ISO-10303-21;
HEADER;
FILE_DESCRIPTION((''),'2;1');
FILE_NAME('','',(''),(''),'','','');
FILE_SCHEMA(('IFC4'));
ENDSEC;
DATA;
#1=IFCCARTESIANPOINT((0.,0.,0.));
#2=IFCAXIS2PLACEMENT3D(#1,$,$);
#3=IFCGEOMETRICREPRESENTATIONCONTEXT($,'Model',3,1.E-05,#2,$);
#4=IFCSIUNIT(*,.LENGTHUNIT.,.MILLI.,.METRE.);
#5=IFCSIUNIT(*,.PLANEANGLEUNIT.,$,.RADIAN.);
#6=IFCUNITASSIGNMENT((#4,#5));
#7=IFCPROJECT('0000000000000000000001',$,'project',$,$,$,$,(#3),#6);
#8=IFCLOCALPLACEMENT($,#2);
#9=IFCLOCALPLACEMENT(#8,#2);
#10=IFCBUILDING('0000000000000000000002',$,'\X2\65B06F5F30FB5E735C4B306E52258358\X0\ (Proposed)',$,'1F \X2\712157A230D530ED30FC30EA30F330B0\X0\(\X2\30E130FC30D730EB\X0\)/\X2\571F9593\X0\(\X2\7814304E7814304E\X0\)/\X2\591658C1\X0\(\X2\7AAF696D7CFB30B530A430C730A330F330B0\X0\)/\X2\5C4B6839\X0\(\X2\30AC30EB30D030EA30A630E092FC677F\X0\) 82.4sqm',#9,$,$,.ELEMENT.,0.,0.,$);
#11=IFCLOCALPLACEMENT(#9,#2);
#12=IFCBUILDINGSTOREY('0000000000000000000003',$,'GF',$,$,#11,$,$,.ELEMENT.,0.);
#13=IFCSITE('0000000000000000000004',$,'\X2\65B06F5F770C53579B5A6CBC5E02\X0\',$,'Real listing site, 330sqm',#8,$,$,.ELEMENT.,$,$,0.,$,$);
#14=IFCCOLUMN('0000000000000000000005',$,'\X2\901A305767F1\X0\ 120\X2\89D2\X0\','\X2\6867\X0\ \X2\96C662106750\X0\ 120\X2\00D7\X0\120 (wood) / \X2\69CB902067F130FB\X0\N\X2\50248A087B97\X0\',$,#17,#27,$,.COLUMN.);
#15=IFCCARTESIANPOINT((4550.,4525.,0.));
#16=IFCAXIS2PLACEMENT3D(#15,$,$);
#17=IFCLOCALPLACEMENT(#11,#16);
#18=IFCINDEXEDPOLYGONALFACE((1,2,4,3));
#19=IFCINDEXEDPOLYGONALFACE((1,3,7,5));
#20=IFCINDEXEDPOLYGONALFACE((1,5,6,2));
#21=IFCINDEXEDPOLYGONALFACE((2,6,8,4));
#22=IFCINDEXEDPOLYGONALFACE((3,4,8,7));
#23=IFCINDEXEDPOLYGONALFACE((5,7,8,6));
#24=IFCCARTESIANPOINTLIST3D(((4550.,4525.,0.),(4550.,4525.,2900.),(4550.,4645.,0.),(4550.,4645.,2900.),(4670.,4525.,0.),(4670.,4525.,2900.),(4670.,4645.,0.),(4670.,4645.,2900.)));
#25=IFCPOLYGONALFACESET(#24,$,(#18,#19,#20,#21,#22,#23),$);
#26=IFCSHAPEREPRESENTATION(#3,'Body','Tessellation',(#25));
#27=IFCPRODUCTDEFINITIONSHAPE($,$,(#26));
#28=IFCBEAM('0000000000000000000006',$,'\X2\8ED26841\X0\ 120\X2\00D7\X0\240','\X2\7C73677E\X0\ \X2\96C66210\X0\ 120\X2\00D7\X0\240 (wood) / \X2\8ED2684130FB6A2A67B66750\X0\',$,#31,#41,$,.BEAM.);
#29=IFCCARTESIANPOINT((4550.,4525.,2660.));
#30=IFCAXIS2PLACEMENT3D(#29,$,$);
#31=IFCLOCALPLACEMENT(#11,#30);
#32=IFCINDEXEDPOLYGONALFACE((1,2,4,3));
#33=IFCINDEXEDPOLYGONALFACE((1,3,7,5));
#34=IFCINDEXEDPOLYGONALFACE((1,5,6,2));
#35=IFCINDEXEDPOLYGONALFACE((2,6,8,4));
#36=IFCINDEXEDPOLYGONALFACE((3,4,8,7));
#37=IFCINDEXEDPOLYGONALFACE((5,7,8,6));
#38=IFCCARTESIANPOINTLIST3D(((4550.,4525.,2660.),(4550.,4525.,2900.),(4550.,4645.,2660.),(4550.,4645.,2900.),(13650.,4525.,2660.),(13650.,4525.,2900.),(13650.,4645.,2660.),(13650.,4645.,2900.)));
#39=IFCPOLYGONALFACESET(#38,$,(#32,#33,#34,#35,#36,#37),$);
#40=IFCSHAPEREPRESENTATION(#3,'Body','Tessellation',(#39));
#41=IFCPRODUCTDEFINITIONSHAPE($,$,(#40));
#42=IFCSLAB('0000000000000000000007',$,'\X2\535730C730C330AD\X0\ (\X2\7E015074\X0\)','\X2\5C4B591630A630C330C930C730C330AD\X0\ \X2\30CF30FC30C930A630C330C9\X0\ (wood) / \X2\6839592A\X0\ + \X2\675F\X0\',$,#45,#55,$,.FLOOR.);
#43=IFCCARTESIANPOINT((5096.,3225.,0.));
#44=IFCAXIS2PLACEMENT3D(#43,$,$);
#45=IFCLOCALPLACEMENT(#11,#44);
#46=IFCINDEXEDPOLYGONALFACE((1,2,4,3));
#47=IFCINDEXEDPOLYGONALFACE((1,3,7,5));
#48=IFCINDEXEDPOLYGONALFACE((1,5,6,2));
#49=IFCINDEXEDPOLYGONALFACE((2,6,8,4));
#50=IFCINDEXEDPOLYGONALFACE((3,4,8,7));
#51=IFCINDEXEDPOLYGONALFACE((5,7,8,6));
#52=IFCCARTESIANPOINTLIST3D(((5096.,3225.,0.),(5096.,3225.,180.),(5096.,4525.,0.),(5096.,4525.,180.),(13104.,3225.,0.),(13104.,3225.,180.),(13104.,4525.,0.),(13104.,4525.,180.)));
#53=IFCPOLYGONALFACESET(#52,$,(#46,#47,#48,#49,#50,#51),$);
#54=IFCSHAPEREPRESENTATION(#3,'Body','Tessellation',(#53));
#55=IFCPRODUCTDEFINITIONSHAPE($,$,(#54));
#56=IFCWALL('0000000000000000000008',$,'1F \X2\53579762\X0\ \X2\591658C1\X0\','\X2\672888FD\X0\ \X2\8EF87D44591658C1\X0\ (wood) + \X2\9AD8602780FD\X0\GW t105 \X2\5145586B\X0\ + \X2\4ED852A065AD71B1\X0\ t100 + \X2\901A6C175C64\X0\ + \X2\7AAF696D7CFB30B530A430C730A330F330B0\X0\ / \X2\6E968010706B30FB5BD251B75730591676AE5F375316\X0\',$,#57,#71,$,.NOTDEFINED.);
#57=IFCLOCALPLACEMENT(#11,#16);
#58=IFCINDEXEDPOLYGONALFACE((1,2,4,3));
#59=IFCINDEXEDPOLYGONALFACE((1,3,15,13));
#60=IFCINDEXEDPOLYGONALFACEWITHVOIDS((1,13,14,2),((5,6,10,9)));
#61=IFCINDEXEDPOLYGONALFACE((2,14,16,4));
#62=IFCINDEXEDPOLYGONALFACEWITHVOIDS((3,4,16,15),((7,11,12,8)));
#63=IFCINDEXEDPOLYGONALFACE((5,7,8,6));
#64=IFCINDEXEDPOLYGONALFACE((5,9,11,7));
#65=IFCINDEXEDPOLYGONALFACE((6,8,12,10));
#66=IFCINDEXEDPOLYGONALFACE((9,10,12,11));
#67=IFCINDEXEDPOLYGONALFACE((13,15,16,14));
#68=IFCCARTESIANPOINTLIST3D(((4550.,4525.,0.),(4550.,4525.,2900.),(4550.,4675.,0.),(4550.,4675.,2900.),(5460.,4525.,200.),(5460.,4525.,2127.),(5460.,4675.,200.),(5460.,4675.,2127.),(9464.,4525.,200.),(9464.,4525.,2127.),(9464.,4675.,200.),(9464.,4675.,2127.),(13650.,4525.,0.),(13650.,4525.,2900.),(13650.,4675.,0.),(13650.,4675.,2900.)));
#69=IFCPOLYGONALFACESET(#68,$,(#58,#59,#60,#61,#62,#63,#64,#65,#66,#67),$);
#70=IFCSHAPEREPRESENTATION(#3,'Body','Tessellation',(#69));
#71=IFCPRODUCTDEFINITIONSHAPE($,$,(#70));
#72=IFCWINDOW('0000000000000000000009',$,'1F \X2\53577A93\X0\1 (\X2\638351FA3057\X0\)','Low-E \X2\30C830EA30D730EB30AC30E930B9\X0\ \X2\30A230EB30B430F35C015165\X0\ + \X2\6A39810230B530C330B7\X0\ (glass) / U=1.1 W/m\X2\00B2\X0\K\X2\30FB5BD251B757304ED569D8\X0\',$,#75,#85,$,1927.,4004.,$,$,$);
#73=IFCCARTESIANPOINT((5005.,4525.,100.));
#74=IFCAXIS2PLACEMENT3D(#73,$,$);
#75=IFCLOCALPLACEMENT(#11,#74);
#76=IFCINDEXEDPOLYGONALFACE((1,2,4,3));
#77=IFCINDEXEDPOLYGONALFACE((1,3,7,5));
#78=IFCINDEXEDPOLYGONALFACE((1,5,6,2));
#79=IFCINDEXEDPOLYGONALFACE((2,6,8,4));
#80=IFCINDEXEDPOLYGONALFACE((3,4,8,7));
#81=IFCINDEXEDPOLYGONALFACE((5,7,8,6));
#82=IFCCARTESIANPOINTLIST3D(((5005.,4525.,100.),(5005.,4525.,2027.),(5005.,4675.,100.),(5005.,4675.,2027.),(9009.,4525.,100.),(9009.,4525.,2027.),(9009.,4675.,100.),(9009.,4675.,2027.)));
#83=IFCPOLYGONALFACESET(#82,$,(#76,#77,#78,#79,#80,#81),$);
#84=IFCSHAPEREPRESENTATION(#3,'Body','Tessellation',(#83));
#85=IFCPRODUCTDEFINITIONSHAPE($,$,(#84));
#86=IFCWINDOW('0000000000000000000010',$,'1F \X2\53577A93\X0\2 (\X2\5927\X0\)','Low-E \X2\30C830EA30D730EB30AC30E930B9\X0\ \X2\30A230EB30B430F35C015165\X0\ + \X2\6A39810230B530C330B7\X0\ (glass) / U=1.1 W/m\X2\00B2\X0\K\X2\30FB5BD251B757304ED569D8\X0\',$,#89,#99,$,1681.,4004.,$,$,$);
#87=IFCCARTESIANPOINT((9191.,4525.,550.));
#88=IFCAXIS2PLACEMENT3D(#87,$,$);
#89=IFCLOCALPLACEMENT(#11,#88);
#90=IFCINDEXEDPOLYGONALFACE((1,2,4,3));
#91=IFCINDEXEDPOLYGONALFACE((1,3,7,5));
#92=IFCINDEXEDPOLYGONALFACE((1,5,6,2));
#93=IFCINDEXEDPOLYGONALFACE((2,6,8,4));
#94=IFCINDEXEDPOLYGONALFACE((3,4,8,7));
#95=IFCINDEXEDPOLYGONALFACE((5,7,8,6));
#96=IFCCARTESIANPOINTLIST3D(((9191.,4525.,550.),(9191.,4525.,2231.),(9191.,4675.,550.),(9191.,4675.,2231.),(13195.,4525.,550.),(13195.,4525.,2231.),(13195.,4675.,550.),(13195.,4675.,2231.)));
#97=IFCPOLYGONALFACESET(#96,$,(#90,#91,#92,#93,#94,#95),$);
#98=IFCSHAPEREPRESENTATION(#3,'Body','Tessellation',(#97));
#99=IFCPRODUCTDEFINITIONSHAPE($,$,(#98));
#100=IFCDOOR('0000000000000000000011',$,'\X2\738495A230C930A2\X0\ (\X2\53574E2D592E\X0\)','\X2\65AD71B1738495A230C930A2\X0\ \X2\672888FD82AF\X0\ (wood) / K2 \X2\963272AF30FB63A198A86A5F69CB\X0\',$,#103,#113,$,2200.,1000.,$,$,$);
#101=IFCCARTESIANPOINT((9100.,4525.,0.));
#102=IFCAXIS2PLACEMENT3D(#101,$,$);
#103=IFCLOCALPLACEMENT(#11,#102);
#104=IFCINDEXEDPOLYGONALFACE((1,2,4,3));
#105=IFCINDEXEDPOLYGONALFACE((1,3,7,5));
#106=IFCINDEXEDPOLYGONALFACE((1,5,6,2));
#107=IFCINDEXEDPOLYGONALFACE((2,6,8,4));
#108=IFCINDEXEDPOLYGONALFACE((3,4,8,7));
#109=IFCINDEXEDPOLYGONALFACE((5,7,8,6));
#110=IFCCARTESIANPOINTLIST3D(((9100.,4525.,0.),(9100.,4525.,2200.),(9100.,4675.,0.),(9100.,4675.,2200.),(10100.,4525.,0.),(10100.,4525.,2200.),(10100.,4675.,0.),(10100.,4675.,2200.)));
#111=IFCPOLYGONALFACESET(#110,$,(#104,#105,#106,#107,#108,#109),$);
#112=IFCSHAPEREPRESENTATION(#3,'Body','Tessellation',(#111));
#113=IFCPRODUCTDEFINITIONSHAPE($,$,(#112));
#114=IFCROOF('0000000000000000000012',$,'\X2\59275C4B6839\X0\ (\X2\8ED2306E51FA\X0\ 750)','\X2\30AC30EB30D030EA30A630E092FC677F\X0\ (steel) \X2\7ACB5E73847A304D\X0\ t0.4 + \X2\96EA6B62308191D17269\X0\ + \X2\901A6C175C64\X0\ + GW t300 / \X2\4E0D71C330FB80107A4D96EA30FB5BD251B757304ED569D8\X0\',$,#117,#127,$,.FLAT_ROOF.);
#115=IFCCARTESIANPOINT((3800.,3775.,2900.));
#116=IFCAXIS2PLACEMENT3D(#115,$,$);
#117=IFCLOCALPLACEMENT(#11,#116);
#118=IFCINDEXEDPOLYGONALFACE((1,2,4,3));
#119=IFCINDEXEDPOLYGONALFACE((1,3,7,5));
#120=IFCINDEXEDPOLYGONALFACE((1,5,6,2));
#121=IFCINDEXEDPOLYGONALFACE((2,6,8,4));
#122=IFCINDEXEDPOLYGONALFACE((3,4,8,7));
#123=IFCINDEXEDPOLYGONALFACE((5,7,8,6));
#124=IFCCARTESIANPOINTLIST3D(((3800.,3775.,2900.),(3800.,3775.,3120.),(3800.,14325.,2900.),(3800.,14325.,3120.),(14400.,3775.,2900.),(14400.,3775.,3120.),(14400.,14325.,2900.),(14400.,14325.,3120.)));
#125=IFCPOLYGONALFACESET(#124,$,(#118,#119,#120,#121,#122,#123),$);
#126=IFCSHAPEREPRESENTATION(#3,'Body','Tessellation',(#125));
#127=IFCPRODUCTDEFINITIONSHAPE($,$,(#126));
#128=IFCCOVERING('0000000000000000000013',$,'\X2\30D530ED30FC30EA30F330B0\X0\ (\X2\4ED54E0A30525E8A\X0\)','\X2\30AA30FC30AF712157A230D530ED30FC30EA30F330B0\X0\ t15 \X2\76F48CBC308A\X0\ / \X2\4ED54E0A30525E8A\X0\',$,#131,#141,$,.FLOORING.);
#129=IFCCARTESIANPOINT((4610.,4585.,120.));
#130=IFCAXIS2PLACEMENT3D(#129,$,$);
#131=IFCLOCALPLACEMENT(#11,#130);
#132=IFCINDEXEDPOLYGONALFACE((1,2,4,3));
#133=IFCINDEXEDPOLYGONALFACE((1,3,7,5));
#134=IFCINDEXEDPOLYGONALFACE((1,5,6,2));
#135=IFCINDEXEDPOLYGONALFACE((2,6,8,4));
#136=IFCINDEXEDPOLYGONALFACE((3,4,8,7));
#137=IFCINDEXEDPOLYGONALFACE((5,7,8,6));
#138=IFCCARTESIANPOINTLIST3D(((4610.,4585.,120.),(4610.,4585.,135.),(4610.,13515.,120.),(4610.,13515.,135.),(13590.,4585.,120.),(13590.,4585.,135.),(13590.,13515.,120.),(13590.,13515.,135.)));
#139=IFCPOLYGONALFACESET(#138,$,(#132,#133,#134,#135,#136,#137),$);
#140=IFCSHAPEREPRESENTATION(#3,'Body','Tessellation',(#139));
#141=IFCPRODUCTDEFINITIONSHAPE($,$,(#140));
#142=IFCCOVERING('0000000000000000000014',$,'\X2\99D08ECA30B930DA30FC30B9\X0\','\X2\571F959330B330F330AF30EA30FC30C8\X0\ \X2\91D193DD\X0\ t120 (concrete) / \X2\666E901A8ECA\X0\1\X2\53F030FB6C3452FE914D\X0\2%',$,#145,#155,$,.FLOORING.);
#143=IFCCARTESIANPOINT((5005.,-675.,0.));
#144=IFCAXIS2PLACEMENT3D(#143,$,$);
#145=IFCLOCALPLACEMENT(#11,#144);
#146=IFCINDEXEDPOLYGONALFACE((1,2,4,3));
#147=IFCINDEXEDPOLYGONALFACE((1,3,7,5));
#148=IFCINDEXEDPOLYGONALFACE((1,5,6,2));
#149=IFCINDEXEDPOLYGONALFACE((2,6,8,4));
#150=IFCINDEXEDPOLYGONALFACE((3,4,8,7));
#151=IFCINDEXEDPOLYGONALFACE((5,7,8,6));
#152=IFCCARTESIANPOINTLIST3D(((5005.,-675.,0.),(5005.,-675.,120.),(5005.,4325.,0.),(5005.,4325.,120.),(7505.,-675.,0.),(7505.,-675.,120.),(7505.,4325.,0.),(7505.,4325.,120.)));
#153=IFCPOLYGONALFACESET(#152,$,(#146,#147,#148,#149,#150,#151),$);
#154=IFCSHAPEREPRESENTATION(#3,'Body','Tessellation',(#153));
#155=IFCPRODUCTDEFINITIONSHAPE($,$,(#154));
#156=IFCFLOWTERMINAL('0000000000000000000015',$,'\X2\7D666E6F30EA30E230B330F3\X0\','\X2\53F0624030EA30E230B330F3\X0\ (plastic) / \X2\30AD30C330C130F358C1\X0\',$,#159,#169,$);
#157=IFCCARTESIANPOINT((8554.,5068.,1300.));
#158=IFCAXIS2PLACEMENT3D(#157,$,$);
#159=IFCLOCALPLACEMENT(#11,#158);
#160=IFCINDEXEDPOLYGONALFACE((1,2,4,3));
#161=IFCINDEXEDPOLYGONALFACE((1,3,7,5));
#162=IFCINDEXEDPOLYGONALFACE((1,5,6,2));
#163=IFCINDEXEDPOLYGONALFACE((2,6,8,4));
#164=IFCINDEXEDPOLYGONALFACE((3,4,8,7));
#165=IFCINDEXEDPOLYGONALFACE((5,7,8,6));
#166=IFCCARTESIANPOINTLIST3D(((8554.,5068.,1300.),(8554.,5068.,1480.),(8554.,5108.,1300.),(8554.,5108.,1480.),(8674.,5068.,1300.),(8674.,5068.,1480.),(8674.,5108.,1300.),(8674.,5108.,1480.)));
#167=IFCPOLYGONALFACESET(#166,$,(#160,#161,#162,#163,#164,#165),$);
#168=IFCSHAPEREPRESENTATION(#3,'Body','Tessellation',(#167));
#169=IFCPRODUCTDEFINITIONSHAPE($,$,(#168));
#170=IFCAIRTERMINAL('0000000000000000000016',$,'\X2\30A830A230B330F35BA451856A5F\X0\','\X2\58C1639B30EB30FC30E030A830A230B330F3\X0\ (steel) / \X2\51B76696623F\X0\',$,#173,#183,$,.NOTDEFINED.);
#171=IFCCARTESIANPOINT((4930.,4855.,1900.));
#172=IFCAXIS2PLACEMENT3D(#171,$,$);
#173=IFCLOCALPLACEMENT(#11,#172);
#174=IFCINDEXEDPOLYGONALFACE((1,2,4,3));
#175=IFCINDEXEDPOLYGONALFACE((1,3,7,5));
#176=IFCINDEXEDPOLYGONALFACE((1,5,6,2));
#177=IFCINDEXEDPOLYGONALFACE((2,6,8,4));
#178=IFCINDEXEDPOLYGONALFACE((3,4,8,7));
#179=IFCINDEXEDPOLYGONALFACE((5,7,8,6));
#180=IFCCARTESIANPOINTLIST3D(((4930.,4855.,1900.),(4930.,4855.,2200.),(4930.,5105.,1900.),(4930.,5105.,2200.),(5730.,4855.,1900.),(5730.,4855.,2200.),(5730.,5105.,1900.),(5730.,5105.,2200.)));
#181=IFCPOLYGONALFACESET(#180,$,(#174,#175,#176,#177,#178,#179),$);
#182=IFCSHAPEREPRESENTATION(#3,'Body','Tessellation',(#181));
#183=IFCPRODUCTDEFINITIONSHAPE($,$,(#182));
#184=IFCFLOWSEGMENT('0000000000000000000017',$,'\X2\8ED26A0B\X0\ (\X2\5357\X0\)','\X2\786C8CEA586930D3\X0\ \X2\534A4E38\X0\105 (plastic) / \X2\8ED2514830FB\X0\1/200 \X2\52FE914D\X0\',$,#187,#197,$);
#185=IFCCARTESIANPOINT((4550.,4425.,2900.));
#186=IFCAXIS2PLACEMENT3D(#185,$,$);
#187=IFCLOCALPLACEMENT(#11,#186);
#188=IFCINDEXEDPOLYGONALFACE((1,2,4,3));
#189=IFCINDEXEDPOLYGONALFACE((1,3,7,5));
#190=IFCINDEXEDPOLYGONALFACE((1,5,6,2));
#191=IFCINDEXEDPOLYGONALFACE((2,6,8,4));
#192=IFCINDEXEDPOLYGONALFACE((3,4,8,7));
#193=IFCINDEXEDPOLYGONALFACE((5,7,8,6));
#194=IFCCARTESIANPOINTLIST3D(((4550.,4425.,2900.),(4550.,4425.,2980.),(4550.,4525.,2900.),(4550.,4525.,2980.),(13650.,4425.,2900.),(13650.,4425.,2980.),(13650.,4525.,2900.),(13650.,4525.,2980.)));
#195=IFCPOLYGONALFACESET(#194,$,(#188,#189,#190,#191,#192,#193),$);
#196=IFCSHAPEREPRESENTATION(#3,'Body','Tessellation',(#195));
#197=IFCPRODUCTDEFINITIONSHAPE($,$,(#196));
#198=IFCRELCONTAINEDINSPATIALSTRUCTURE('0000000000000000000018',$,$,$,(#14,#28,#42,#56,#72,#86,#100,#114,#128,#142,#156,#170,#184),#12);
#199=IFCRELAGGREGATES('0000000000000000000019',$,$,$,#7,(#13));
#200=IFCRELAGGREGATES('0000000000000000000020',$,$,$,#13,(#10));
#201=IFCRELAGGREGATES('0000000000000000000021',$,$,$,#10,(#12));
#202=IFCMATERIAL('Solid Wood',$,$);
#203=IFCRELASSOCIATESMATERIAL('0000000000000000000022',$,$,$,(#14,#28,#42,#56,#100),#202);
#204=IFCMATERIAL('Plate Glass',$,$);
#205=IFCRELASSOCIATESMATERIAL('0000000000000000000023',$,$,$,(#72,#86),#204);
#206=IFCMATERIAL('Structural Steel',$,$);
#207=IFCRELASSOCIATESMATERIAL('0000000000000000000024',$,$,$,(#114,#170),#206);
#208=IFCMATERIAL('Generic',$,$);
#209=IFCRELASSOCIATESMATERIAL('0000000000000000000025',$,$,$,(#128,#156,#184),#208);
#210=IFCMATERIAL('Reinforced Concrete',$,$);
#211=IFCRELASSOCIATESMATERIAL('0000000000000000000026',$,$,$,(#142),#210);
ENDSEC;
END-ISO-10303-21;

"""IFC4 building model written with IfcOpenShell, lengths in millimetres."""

from ifc_helpers import new_model, si_unit, frame, frame_2d, origin, place, context, project, spatial, rectangle, extrude, material, element, fill, save


model = new_model("IFC4")

# Units and contexts
model_context = context("Model", 3, precision=1e-05, world=origin())
ifc_project = project(units=[si_unit("LENGTHUNIT", "METRE", prefix="MILLI"), si_unit("PLANEANGLEUNIT", "RADIAN")], contexts=[model_context])

# Site, building, storey
site_placement = place(None, origin())
site = spatial("IfcSite", under=ifc_project, at=site_placement, Name="新潟県南魚沼市", ObjectType="Real listing site, 330sqm", CompositionType="ELEMENT", RefElevation=0.0)
building_placement = place(site_placement, origin())
building = spatial("IfcBuilding", under=site, at=building_placement, Name="新潟・平屋の別荘 (Proposed)", ObjectType="1F 無垢フローリング(メープル)/土間(研ぎ研ぎ)/外壁(窯業系サイディング)/屋根(ガルバリウム鋼板) 82.4sqm", CompositionType="ELEMENT", ElevationOfRefHeight=0.0, ElevationOfTerrain=0.0)
storey_placement = place(building_placement, origin())
storey = spatial("IfcBuildingStorey", under=building, at=storey_placement, Name="GF", CompositionType="ELEMENT", Elevation=0.0)

# Column
ifc_material_1 = material(Name="Solid Wood")
column_1_placement = place(storey_placement, frame((4550.0, 4525.0, 0.0)))
element("IfcColumn", 1, at=column_1_placement, inside=storey, material=ifc_material_1, Name="通し柱 120角", Description="桧 集成材 120×120 (wood) / 構造柱・N値計算", PredefinedType="COLUMN", context=model_context, shape_type="SweptSolid", body=[
    extrude(rectangle(XDim=120.0, YDim=120.0, at=frame_2d((60.0, 60.0))), frame((4550.0, 4525.0, 0.0)), (0.0, 0.0, 1.0), 2900.0),
])

# Beam
beam_1_placement = place(storey_placement, frame((4550.0, 4525.0, 2660.0)))
element("IfcBeam", 2, at=beam_1_placement, inside=storey, material=ifc_material_1, Name="軒桁 120×240", Description="米松 集成 120×240 (wood) / 軒桁・横架材", PredefinedType="BEAM", context=model_context, shape_type="SweptSolid", body=[
    extrude(rectangle(XDim=9100.0, YDim=120.0, at=frame_2d((4550.0, 60.0))), frame((4550.0, 4525.0, 2660.0)), (0.0, 0.0, 1.0), 240.0),
])

# Slab
ifc_material_2 = material(Name="Reinforced Concrete")
slab_1_placement = place(storey_placement, frame((5096.0, 3225.0, 0.0)))
element("IfcSlab", 3, at=slab_1_placement, inside=storey, material=ifc_material_1, Name="南デッキ (縁側)", Description="屋外ウッドデッキ ハードウッド (wood) / 根太 + 束", PredefinedType="FLOOR", context=model_context, shape_type="SweptSolid", body=[
    extrude(rectangle(XDim=8008.0, YDim=1300.0, at=frame_2d((4004.0, 650.0))), frame((5096.0, 3225.0, 0.0)), (0.0, 0.0, 1.0), 180.0),
])

# Wall, openings, windows, door
wall_1_placement = place(storey_placement, frame((4550.0, 4525.0, 0.0)))
wall_1 = element("IfcWall", 4, at=wall_1_placement, inside=storey, material=ifc_material_1, Name="1F 南面 外壁", Description="木製 軸組外壁 (wood) + 高性能GW t105 充填 + 付加断熱 t100 + 通気層 + 窯業系サイディング / 準耐火・寒冷地外皮強化", PredefinedType="NOTDEFINED", context=model_context, shape_type="SweptSolid", body=[
    extrude(rectangle(XDim=9100.0, YDim=150.0, at=frame_2d((4550.0, 75.0))), frame((4550.0, 4525.0, 0.0)), (0.0, 0.0, 1.0), 2900.0),
])
opening_1_placement = place(storey_placement, frame((5005.0, 4525.0, 100.0)))
opening_1 = element("IfcOpeningElement", 5, at=opening_1_placement, cuts=wall_1, PredefinedType="NOTDEFINED", context=model_context, shape_type="SweptSolid", body=[
    extrude(rectangle(XDim=4004.0, YDim=150.0, at=frame_2d((2002.0, 75.0))), frame((5005.0, 4525.0, 100.0)), (0.0, 0.0, 1.0), 1927.0),
])
opening_2_placement = place(storey_placement, frame((9191.0, 4525.0, 550.0)))
opening_2 = element("IfcOpeningElement", 6, at=opening_2_placement, cuts=wall_1, PredefinedType="NOTDEFINED", context=model_context, shape_type="SweptSolid", body=[
    extrude(rectangle(XDim=4004.0, YDim=150.0, at=frame_2d((2002.0, 75.0))), frame((9191.0, 4525.0, 550.0)), (0.0, 0.0, 1.0), 1681.0),
])
opening_3_placement = place(storey_placement, frame((9100.0, 4525.0, 0.0)))
opening_3 = element("IfcOpeningElement", 7, at=opening_3_placement, cuts=wall_1, PredefinedType="NOTDEFINED", context=model_context, shape_type="SweptSolid", body=[
    extrude(rectangle(XDim=1000.0, YDim=150.0, at=frame_2d((500.0, 75.0))), frame((9100.0, 4525.0, 0.0)), (0.0, 0.0, 1.0), 2200.0),
])
ifc_material_3 = material(Name="Plate Glass")
window_1_placement = place(storey_placement, frame((5005.0, 4525.0, 100.0)))
window_1 = element("IfcWindow", 8, at=window_1_placement, inside=storey, material=ifc_material_3, Name="1F 南窓1 (掃出し)", Description="Low-E トリプルガラス アルゴン封入 + 樹脂サッシ (glass) / U=1.1 W/m²K・寒冷地仕様", OverallHeight=1927.0, OverallWidth=4004.0, context=model_context, shape_type="SweptSolid", body=[
    extrude(rectangle(XDim=4004.0, YDim=150.0, at=frame_2d((2002.0, 75.0))), frame((5005.0, 4525.0, 100.0)), (0.0, 0.0, 1.0), 1927.0),
])
fill(opening_1, window_1)
window_2_placement = place(storey_placement, frame((9191.0, 4525.0, 550.0)))
window_2 = element("IfcWindow", 9, at=window_2_placement, inside=storey, material=ifc_material_3, Name="1F 南窓2 (大)", Description="Low-E トリプルガラス アルゴン封入 + 樹脂サッシ (glass) / U=1.1 W/m²K・寒冷地仕様", OverallHeight=1681.0, OverallWidth=4004.0, context=model_context, shape_type="SweptSolid", body=[
    extrude(rectangle(XDim=4004.0, YDim=150.0, at=frame_2d((2002.0, 75.0))), frame((9191.0, 4525.0, 550.0)), (0.0, 0.0, 1.0), 1681.0),
])
fill(opening_2, window_2)
door_placement = place(storey_placement, frame((9100.0, 4525.0, 0.0)))
door = element("IfcDoor", 10, at=door_placement, inside=storey, material=ifc_material_1, Name="玄関ドア (南中央)", Description="断熱玄関ドア 木製芯 (wood) / K2 防犯・採風機構", OverallHeight=2200.0, OverallWidth=1000.0, context=model_context, shape_type="SweptSolid", body=[
    extrude(rectangle(XDim=1000.0, YDim=150.0, at=frame_2d((500.0, 75.0))), frame((9100.0, 4525.0, 0.0)), (0.0, 0.0, 1.0), 2200.0),
])
fill(opening_3, door)

# Roof
ifc_material_4 = material(Name="Structural Steel")
roof_placement = place(storey_placement, frame((3800.0, 3775.0, 2900.0)))
element("IfcRoof", 11, at=roof_placement, inside=storey, material=ifc_material_4, Name="大屋根 (軒の出 750)", Description="ガルバリウム鋼板 (steel) 立平葺き t0.4 + 雪止め金物 + 通気層 + GW t300 / 不燃・耐積雪・寒冷地仕様", PredefinedType="FLAT_ROOF", context=model_context, shape_type="SweptSolid", body=[
    extrude(rectangle(XDim=10600.0, YDim=10550.0, at=frame_2d((5300.0, 5275.0))), frame((3800.0, 3775.0, 2900.0)), (0.0, 0.0, 1.0), 220.0),
])

# Coverings
ifc_material_5 = material(Name="Generic")
covering_1_placement = place(storey_placement, frame((4610.0, 4585.0, 120.0)))
element("IfcCovering", 12, at=covering_1_placement, inside=storey, material=ifc_material_5, Name="フローリング (仕上げ床)", Description="オーク無垢フローリング t15 直貼り / 仕上げ床", PredefinedType="FLOORING", context=model_context, shape_type="SweptSolid", body=[
    extrude(rectangle(XDim=8980.0, YDim=8930.0, at=frame_2d((4490.0, 4465.0))), frame((4610.0, 4585.0, 120.0)), (0.0, 0.0, 1.0), 15.0),
])
covering_2_placement = place(storey_placement, frame((5005.0, -675.0, 0.0)))
element("IfcCovering", 13, at=covering_2_placement, inside=storey, material=ifc_material_2, Name="駐車スペース", Description="土間コンクリート 金鏝 t120 (concrete) / 普通車1台・水勾配2%", PredefinedType="FLOORING", context=model_context, shape_type="SweptSolid", body=[
    extrude(rectangle(XDim=2500.0, YDim=5000.0, at=frame_2d((1250.0, 2500.0))), frame((5005.0, -675.0, 0.0)), (0.0, 0.0, 1.0), 120.0),
])

# Flow terminal
flow_terminal_placement = place(storey_placement, frame((8554.0, 5068.0, 1300.0)))
element("IfcFlowTerminal", 14, at=flow_terminal_placement, inside=storey, material=ifc_material_5, Name="給湯リモコン", Description="台所リモコン (plastic) / キッチン壁", context=model_context, shape_type="SweptSolid", body=[
    extrude(rectangle(XDim=120.0, YDim=40.0, at=frame_2d((60.0, 20.0))), frame((8554.0, 5068.0, 1300.0)), (0.0, 0.0, 1.0), 180.0),
])

# Air terminal
air_terminal_placement = place(storey_placement, frame((4930.0, 4855.0, 1900.0)))
element("IfcAirTerminal", 15, at=air_terminal_placement, inside=storey, material=ifc_material_4, Name="エアコン室内機", Description="壁掛ルームエアコン (steel) / 冷暖房", PredefinedType="NOTDEFINED", context=model_context, shape_type="SweptSolid", body=[
    extrude(rectangle(XDim=800.0, YDim=250.0, at=frame_2d((400.0, 125.0))), frame((4930.0, 4855.0, 1900.0)), (0.0, 0.0, 1.0), 300.0),
])

# Flow segment
flow_segment_1_placement = place(storey_placement, frame((4550.0, 4425.0, 2900.0)))
element("IfcFlowSegment", 16, at=flow_segment_1_placement, inside=storey, material=ifc_material_5, Name="軒樋 (南)", Description="硬質塩ビ 半丸105 (plastic) / 軒先・1/200 勾配", context=model_context, shape_type="SweptSolid", body=[
    extrude(rectangle(XDim=9100.0, YDim=100.0, at=frame_2d((4550.0, 50.0))), frame((4550.0, 4425.0, 2900.0)), (0.0, 0.0, 1.0), 80.0),
])

save(model, "model.ifc")
